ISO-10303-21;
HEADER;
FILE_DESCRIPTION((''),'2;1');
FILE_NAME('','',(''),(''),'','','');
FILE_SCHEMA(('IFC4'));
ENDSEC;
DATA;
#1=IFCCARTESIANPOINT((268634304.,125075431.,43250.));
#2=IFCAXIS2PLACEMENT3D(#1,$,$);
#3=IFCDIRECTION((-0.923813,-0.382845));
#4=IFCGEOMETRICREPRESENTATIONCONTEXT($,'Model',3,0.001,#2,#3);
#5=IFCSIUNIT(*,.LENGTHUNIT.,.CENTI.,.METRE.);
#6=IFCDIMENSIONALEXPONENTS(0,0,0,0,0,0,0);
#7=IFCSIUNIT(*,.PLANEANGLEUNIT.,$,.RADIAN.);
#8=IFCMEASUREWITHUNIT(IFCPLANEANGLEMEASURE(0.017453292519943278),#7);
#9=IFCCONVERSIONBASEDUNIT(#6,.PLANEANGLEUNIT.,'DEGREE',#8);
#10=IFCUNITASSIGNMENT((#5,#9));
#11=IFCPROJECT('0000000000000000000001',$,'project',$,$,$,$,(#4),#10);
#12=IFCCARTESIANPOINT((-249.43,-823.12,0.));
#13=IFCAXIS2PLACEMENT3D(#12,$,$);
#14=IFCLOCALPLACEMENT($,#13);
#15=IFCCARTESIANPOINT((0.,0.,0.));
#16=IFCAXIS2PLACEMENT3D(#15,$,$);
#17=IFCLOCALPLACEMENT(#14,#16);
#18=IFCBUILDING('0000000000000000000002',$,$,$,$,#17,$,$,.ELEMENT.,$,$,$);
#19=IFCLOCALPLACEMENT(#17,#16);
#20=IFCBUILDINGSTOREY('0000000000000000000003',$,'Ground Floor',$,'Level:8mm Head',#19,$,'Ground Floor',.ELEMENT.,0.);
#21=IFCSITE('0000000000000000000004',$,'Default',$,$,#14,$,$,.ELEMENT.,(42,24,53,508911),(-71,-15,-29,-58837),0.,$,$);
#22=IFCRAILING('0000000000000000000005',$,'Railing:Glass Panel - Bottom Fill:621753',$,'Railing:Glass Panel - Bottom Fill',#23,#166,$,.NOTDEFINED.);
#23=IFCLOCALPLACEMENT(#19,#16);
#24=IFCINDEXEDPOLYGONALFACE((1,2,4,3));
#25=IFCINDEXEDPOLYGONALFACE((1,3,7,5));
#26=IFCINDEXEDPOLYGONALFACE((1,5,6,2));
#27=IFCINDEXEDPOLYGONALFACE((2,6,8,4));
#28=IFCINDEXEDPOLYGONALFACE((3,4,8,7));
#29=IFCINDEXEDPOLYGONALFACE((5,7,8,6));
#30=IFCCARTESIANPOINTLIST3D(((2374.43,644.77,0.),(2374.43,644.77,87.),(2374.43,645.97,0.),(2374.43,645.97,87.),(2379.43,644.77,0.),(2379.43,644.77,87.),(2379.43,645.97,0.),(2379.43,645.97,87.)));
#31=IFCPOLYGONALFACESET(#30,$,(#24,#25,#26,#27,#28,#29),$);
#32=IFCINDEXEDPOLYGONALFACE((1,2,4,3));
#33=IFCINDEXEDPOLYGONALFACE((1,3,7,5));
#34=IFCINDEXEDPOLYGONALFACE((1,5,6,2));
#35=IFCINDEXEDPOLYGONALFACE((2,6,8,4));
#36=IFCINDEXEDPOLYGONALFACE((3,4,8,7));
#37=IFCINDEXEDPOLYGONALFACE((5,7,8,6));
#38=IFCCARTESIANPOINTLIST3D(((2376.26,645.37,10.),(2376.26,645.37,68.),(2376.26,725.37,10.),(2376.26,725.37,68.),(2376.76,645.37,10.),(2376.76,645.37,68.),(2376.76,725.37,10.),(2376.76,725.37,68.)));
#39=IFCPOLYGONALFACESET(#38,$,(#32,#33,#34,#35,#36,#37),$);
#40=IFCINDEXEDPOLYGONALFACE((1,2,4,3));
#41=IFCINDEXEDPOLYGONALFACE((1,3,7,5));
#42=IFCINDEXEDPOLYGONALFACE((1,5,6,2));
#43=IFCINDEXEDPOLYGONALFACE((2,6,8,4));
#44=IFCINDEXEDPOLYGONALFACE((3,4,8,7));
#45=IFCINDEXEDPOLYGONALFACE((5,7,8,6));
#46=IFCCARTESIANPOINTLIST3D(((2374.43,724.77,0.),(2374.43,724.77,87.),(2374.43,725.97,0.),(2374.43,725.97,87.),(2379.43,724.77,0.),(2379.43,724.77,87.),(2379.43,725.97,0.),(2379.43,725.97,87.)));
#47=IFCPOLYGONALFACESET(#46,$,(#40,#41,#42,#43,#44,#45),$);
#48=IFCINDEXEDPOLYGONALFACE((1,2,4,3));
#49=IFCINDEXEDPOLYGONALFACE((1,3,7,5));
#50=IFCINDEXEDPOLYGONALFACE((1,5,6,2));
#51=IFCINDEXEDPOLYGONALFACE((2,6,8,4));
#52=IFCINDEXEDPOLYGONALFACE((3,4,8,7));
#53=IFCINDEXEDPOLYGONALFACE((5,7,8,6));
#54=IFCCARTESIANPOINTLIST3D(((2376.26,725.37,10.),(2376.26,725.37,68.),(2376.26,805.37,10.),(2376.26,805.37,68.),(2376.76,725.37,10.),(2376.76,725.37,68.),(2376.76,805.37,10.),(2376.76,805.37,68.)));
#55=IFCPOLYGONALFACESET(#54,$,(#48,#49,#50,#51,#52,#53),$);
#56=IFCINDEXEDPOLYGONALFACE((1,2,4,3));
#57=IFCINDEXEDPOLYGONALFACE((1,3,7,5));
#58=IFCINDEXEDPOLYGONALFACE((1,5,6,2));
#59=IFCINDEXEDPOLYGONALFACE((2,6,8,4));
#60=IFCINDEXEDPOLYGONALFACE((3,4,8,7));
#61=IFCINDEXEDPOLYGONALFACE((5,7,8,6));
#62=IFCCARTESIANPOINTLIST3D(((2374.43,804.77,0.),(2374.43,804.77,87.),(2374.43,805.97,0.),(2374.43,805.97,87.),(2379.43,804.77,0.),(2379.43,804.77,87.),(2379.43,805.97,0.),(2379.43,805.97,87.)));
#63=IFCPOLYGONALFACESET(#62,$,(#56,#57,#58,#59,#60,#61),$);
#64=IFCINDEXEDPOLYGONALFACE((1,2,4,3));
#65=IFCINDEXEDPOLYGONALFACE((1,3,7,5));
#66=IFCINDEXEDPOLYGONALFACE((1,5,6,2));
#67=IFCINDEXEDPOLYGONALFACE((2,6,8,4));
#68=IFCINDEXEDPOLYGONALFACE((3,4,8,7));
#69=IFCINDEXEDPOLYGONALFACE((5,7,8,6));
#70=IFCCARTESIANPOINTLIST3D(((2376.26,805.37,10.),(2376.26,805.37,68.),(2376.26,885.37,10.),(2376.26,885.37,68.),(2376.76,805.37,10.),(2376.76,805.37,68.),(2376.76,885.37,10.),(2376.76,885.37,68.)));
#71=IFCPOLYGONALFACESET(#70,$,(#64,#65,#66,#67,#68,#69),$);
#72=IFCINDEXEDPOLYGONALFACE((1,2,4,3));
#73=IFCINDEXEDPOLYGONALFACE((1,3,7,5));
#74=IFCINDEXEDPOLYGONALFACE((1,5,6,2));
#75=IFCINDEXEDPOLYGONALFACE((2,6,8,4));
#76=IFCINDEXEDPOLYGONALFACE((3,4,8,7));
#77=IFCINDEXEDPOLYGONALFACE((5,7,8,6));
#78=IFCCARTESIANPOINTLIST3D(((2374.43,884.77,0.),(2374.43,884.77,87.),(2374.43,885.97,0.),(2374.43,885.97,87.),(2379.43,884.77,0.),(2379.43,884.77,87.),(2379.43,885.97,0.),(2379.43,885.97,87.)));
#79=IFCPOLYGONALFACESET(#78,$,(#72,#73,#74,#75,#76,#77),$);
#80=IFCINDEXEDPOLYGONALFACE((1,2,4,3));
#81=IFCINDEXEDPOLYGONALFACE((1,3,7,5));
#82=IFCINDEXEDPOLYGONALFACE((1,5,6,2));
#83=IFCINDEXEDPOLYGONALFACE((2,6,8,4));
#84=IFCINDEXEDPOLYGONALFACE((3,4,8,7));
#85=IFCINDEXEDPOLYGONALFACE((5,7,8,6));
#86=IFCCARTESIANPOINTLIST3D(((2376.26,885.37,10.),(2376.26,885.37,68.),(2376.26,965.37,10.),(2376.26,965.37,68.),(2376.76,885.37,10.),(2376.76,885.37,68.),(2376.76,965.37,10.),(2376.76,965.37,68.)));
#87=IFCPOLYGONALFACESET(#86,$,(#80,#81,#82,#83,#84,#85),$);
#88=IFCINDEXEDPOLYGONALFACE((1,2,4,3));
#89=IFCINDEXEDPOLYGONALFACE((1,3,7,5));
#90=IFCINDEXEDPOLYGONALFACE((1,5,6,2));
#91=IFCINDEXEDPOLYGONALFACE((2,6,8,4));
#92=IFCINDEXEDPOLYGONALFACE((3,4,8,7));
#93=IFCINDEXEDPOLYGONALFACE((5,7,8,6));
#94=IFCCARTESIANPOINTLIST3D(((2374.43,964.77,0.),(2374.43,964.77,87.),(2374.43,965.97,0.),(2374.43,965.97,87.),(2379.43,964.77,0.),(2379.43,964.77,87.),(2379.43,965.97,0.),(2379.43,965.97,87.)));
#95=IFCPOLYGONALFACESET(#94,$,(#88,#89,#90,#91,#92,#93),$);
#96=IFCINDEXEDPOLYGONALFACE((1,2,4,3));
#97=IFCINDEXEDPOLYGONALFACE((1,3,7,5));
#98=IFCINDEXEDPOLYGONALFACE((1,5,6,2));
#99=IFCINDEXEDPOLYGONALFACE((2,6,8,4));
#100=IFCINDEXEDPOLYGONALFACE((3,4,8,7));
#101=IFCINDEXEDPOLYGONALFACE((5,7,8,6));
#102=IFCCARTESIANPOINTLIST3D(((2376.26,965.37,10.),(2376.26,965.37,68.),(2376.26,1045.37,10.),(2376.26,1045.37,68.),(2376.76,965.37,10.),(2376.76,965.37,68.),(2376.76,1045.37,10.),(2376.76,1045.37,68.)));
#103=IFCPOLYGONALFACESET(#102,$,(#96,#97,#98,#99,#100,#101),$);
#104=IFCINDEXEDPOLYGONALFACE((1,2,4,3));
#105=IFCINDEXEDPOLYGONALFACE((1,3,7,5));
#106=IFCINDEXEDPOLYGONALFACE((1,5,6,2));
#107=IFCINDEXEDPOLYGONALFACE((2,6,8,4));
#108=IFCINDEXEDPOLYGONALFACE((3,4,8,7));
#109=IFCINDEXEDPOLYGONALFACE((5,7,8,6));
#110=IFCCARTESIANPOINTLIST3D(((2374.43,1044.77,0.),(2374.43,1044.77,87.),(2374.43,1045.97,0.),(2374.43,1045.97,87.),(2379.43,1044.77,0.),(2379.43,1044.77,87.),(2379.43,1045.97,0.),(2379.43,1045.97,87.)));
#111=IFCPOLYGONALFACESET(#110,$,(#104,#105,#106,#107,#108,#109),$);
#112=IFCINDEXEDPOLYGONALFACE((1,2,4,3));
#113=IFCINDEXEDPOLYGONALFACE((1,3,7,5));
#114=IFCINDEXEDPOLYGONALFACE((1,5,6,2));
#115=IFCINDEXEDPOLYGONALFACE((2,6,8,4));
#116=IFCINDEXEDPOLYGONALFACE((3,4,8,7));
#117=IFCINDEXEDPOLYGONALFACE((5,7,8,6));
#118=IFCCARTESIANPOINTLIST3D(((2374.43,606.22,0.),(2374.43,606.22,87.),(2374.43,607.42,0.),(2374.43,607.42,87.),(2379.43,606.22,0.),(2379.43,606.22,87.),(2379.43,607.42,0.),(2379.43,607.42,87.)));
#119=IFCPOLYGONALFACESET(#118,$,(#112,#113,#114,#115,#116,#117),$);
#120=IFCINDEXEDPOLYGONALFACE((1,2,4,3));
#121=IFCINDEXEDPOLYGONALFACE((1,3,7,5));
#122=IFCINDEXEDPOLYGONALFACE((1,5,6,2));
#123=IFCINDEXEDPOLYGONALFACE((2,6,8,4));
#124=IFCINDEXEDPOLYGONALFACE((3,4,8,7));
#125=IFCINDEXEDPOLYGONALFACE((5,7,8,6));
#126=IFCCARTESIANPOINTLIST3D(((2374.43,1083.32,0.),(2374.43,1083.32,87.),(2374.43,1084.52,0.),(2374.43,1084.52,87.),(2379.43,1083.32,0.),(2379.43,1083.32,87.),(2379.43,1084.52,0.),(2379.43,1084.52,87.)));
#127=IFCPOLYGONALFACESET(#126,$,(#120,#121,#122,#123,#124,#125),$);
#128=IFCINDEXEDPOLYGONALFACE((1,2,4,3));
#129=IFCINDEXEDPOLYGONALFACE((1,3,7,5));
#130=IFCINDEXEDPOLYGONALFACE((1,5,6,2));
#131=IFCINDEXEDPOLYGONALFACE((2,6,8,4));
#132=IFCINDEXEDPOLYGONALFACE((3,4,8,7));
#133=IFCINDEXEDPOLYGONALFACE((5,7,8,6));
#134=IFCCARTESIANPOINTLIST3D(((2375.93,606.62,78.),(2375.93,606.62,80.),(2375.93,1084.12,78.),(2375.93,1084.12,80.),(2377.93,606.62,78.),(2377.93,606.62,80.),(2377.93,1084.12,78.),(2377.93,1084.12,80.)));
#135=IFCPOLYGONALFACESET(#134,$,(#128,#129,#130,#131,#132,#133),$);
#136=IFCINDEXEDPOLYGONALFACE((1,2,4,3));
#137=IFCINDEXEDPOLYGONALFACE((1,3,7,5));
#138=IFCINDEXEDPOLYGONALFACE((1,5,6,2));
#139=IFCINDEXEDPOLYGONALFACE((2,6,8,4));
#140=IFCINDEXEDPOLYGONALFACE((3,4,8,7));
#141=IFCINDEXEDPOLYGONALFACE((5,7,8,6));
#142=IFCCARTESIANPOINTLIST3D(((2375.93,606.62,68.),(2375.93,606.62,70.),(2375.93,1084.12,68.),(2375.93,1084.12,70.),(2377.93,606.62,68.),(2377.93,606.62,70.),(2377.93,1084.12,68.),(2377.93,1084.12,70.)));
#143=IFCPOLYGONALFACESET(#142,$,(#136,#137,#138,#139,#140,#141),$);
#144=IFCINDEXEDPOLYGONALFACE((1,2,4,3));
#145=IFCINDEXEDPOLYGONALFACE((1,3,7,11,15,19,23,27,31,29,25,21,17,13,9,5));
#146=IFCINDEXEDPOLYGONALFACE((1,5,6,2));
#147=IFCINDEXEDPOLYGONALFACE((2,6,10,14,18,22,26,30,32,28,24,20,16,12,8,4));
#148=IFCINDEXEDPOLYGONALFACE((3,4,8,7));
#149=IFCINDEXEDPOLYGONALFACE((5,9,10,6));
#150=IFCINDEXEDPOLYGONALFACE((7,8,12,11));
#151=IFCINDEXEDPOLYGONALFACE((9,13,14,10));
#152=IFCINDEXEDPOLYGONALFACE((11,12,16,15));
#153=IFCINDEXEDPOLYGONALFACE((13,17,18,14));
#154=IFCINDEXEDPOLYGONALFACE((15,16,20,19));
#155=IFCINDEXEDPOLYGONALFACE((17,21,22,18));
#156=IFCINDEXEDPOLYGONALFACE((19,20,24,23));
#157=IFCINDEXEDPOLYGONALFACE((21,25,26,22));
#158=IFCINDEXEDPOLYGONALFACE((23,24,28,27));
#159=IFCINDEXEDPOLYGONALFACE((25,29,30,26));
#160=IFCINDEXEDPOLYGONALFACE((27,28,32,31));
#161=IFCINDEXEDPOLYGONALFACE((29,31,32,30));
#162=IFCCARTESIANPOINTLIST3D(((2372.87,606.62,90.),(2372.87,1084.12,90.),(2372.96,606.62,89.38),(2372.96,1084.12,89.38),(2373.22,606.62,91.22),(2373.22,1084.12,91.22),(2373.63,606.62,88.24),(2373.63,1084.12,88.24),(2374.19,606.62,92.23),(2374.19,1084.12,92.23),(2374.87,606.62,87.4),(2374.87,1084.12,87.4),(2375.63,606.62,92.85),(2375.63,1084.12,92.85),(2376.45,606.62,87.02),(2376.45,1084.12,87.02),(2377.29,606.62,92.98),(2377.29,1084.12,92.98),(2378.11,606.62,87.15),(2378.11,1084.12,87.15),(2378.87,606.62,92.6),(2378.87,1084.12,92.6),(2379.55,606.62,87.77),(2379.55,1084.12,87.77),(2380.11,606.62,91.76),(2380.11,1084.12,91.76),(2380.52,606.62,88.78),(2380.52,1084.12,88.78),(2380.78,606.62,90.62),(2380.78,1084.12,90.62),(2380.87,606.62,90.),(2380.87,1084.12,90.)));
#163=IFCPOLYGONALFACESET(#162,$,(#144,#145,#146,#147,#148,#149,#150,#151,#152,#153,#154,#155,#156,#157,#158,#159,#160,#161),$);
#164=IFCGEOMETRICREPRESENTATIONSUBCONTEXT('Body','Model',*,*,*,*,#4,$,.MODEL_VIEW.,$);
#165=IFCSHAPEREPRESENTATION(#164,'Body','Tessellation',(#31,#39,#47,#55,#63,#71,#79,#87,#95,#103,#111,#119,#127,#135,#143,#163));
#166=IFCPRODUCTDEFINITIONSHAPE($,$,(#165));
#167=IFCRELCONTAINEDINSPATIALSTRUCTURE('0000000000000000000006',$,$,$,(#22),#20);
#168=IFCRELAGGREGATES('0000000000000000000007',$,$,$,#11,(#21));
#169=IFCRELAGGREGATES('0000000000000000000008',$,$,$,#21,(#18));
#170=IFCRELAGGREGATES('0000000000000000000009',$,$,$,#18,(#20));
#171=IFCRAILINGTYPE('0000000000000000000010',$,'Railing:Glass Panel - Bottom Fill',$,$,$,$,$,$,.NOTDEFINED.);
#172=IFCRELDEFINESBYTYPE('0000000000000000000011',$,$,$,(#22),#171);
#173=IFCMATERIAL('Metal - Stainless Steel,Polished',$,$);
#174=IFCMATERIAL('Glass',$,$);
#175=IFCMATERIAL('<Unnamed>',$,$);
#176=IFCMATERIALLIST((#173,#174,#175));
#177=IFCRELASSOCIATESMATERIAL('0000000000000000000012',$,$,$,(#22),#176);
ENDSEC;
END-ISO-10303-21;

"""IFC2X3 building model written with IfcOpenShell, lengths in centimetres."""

from ifc_helpers import new_model, entity, si_unit, converted_unit, direction, frame, frame_2d, origin, place, context, subcontext, project, spatial, polyline, rectangle, outline, extrude, material, material_list, type_object, element, save


model = new_model("IFC2X3")

# Units and contexts
model_context = context("Model", 3, precision=0.001, world=frame((268634304.0, 125075431.0, 43250.0)), true_north=direction((-0.923813, -0.382845)))
body_context = subcontext(model_context, "Body", "Model", "MODEL_VIEW")
ifc_project = project(units=[si_unit("LENGTHUNIT", "METRE", prefix="CENTI"), converted_unit("PLANEANGLEUNIT", "DEGREE", entity("IfcPlaneAngleMeasure", 0.017453292519943278), si_unit("PLANEANGLEUNIT", "RADIAN"), dimensions=[0, 0, 0, 0, 0, 0, 0])], contexts=[model_context])

# Site, building, storey
site_placement = place(None, frame((-249.43, -823.12, 0.0)))
site = spatial("IfcSite", under=ifc_project, at=site_placement, Name="Default", CompositionType="ELEMENT", RefLatitude=(42, 24, 53, 508911), RefLongitude=(-71, -15, -29, -58837), RefElevation=0.0)
building_placement = place(site_placement, origin())
building = spatial("IfcBuilding", under=site, at=building_placement, CompositionType="ELEMENT")
storey_placement = place(building_placement, origin())
storey = spatial("IfcBuildingStorey", under=building, at=storey_placement, Name="Ground Floor", ObjectType="Level:8mm Head", LongName="Ground Floor", CompositionType="ELEMENT", Elevation=0.0)

# Shared definitions
ifc_material_1 = material(Name="Glass")

# Railing
ifc_material_2 = material(Name="Metal - Stainless Steel,Polished")
ifc_material_3 = material(Name="<Unnamed>")
ifc_material_list = material_list([ifc_material_2, ifc_material_1, ifc_material_3])
railing_type = type_object("IfcRailingType", Name="Railing:Glass Panel - Bottom Fill", PredefinedType="NOTDEFINED")
railing_1_placement = place(storey_placement, frame((2372.71, 606.22, 0.0)))
element("IfcRailing", 1, at=railing_1_placement, inside=storey, type_object=railing_type, material=ifc_material_list, Name="Railing:Glass Panel - Bottom Fill:621753", ObjectType="Railing:Glass Panel - Bottom Fill", PredefinedType="NOTDEFINED", context=body_context, shape_type="SweptSolid", body=[
    extrude(rectangle(XDim=5.0, YDim=1.2, at=frame_2d((0.0, 0.0), x_axis=(1.0, 0.0))), frame((4.22, 39.15, 0.0), z_axis=(0.0, 0.0, 1.0), x_axis=(-1.0, 0.0, 0.0)), (0.0, 0.0, 1.0), 87.0),
    extrude(rectangle(XDim=0.5, YDim=80.0, at=frame_2d((0.0, 0.0), x_axis=(1.0, 0.0))), frame((3.8, 79.15, 10.0), z_axis=(0.0, 0.0, 1.0), x_axis=(-1.0, 0.0, 0.0)), (0.0, 0.0, 1.0), 58.0),
    extrude(rectangle(XDim=5.0, YDim=1.2, at=frame_2d((0.0, 0.0), x_axis=(1.0, 0.0))), frame((4.22, 119.15, 0.0), z_axis=(0.0, 0.0, 1.0), x_axis=(-1.0, 0.0, 0.0)), (0.0, 0.0, 1.0), 87.0),
    extrude(rectangle(XDim=0.5, YDim=80.0, at=frame_2d((0.0, 0.0), x_axis=(1.0, 0.0))), frame((3.8, 159.15, 10.0), z_axis=(0.0, 0.0, 1.0), x_axis=(-1.0, 0.0, 0.0)), (0.0, 0.0, 1.0), 58.0),
    extrude(rectangle(XDim=5.0, YDim=1.2, at=frame_2d((0.0, 0.0), x_axis=(1.0, 0.0))), frame((4.22, 199.15, 0.0), z_axis=(0.0, 0.0, 1.0), x_axis=(-1.0, 0.0, 0.0)), (0.0, 0.0, 1.0), 87.0),
    extrude(rectangle(XDim=0.5, YDim=80.0, at=frame_2d((0.0, 0.0), x_axis=(1.0, 0.0))), frame((3.8, 239.15, 10.0), z_axis=(0.0, 0.0, 1.0), x_axis=(-1.0, 0.0, 0.0)), (0.0, 0.0, 1.0), 58.0),
    extrude(rectangle(XDim=5.0, YDim=1.2, at=frame_2d((0.0, 0.0), x_axis=(1.0, 0.0))), frame((4.22, 279.15, 0.0), z_axis=(0.0, 0.0, 1.0), x_axis=(-1.0, 0.0, 0.0)), (0.0, 0.0, 1.0), 87.0),
    extrude(rectangle(XDim=0.5, YDim=80.0, at=frame_2d((0.0, 0.0), x_axis=(1.0, 0.0))), frame((3.8, 319.15, 10.0), z_axis=(0.0, 0.0, 1.0), x_axis=(-1.0, 0.0, 0.0)), (0.0, 0.0, 1.0), 58.0),
    extrude(rectangle(XDim=5.0, YDim=1.2, at=frame_2d((0.0, 0.0), x_axis=(1.0, 0.0))), frame((4.22, 359.15, 0.0), z_axis=(0.0, 0.0, 1.0), x_axis=(-1.0, 0.0, 0.0)), (0.0, 0.0, 1.0), 87.0),
    extrude(rectangle(XDim=0.5, YDim=80.0, at=frame_2d((0.0, 0.0), x_axis=(1.0, 0.0))), frame((3.8, 399.15, 10.0), z_axis=(0.0, 0.0, 1.0), x_axis=(-1.0, 0.0, 0.0)), (0.0, 0.0, 1.0), 58.0),
    extrude(rectangle(XDim=5.0, YDim=1.2, at=frame_2d((0.0, 0.0), x_axis=(1.0, 0.0))), frame((4.22, 439.15, 0.0), z_axis=(0.0, 0.0, 1.0), x_axis=(-1.0, 0.0, 0.0)), (0.0, 0.0, 1.0), 87.0),
    extrude(rectangle(XDim=5.0, YDim=1.2, at=frame_2d((0.0, 0.0), x_axis=(1.0, 0.0))), frame((4.22, 0.6, 0.0), z_axis=(0.0, 0.0, 1.0), x_axis=(-1.0, 0.0, 0.0)), (0.0, 0.0, 1.0), 87.0),
    extrude(rectangle(XDim=5.0, YDim=1.2, at=frame_2d((0.0, 0.0), x_axis=(1.0, 0.0))), frame((4.22, 477.7, 0.0), z_axis=(0.0, 0.0, 1.0), x_axis=(-1.0, 0.0, 0.0)), (0.0, 0.0, 1.0), 87.0),
    extrude(rectangle(XDim=477.5, YDim=2.0, at=frame_2d((0.0, 0.0), x_axis=(1.0, 0.0))), frame((4.22, 239.15, 78.0), z_axis=(0.0, 0.0, 1.0), x_axis=(0.0, -1.0, 0.0)), (0.0, 0.0, 1.0), 2.0),
    extrude(rectangle(XDim=477.5, YDim=2.0, at=frame_2d((0.0, 0.0), x_axis=(1.0, 0.0))), frame((4.22, 239.15, 68.0), z_axis=(0.0, 0.0, 1.0), x_axis=(0.0, -1.0, 0.0)), (0.0, 0.0, 1.0), 2.0),
    extrude(outline(polyline([(-1.09, -3.85), (0.18, -3.85), (1.42, -3.18), (2.41, -1.97), (2.98, -0.41), (3.04, 1.22), (2.58, 2.63), (1.67, 3.59), (1.09, 3.85), (-0.18, 3.85), (-1.42, 3.18), (-2.41, 1.97), (-2.98, 0.41), (-3.04, -1.22), (-2.58, -2.63), (-1.67, -3.59), (-1.09, -3.85)])), frame((4.16, 0.4, 90.0), z_axis=(0.0, 1.0, 0.0), x_axis=(-0.27267, 0.0, -0.962108)), (0.0, 0.0, 1.0), 477.5),
])

save(model, "model.ifc")
